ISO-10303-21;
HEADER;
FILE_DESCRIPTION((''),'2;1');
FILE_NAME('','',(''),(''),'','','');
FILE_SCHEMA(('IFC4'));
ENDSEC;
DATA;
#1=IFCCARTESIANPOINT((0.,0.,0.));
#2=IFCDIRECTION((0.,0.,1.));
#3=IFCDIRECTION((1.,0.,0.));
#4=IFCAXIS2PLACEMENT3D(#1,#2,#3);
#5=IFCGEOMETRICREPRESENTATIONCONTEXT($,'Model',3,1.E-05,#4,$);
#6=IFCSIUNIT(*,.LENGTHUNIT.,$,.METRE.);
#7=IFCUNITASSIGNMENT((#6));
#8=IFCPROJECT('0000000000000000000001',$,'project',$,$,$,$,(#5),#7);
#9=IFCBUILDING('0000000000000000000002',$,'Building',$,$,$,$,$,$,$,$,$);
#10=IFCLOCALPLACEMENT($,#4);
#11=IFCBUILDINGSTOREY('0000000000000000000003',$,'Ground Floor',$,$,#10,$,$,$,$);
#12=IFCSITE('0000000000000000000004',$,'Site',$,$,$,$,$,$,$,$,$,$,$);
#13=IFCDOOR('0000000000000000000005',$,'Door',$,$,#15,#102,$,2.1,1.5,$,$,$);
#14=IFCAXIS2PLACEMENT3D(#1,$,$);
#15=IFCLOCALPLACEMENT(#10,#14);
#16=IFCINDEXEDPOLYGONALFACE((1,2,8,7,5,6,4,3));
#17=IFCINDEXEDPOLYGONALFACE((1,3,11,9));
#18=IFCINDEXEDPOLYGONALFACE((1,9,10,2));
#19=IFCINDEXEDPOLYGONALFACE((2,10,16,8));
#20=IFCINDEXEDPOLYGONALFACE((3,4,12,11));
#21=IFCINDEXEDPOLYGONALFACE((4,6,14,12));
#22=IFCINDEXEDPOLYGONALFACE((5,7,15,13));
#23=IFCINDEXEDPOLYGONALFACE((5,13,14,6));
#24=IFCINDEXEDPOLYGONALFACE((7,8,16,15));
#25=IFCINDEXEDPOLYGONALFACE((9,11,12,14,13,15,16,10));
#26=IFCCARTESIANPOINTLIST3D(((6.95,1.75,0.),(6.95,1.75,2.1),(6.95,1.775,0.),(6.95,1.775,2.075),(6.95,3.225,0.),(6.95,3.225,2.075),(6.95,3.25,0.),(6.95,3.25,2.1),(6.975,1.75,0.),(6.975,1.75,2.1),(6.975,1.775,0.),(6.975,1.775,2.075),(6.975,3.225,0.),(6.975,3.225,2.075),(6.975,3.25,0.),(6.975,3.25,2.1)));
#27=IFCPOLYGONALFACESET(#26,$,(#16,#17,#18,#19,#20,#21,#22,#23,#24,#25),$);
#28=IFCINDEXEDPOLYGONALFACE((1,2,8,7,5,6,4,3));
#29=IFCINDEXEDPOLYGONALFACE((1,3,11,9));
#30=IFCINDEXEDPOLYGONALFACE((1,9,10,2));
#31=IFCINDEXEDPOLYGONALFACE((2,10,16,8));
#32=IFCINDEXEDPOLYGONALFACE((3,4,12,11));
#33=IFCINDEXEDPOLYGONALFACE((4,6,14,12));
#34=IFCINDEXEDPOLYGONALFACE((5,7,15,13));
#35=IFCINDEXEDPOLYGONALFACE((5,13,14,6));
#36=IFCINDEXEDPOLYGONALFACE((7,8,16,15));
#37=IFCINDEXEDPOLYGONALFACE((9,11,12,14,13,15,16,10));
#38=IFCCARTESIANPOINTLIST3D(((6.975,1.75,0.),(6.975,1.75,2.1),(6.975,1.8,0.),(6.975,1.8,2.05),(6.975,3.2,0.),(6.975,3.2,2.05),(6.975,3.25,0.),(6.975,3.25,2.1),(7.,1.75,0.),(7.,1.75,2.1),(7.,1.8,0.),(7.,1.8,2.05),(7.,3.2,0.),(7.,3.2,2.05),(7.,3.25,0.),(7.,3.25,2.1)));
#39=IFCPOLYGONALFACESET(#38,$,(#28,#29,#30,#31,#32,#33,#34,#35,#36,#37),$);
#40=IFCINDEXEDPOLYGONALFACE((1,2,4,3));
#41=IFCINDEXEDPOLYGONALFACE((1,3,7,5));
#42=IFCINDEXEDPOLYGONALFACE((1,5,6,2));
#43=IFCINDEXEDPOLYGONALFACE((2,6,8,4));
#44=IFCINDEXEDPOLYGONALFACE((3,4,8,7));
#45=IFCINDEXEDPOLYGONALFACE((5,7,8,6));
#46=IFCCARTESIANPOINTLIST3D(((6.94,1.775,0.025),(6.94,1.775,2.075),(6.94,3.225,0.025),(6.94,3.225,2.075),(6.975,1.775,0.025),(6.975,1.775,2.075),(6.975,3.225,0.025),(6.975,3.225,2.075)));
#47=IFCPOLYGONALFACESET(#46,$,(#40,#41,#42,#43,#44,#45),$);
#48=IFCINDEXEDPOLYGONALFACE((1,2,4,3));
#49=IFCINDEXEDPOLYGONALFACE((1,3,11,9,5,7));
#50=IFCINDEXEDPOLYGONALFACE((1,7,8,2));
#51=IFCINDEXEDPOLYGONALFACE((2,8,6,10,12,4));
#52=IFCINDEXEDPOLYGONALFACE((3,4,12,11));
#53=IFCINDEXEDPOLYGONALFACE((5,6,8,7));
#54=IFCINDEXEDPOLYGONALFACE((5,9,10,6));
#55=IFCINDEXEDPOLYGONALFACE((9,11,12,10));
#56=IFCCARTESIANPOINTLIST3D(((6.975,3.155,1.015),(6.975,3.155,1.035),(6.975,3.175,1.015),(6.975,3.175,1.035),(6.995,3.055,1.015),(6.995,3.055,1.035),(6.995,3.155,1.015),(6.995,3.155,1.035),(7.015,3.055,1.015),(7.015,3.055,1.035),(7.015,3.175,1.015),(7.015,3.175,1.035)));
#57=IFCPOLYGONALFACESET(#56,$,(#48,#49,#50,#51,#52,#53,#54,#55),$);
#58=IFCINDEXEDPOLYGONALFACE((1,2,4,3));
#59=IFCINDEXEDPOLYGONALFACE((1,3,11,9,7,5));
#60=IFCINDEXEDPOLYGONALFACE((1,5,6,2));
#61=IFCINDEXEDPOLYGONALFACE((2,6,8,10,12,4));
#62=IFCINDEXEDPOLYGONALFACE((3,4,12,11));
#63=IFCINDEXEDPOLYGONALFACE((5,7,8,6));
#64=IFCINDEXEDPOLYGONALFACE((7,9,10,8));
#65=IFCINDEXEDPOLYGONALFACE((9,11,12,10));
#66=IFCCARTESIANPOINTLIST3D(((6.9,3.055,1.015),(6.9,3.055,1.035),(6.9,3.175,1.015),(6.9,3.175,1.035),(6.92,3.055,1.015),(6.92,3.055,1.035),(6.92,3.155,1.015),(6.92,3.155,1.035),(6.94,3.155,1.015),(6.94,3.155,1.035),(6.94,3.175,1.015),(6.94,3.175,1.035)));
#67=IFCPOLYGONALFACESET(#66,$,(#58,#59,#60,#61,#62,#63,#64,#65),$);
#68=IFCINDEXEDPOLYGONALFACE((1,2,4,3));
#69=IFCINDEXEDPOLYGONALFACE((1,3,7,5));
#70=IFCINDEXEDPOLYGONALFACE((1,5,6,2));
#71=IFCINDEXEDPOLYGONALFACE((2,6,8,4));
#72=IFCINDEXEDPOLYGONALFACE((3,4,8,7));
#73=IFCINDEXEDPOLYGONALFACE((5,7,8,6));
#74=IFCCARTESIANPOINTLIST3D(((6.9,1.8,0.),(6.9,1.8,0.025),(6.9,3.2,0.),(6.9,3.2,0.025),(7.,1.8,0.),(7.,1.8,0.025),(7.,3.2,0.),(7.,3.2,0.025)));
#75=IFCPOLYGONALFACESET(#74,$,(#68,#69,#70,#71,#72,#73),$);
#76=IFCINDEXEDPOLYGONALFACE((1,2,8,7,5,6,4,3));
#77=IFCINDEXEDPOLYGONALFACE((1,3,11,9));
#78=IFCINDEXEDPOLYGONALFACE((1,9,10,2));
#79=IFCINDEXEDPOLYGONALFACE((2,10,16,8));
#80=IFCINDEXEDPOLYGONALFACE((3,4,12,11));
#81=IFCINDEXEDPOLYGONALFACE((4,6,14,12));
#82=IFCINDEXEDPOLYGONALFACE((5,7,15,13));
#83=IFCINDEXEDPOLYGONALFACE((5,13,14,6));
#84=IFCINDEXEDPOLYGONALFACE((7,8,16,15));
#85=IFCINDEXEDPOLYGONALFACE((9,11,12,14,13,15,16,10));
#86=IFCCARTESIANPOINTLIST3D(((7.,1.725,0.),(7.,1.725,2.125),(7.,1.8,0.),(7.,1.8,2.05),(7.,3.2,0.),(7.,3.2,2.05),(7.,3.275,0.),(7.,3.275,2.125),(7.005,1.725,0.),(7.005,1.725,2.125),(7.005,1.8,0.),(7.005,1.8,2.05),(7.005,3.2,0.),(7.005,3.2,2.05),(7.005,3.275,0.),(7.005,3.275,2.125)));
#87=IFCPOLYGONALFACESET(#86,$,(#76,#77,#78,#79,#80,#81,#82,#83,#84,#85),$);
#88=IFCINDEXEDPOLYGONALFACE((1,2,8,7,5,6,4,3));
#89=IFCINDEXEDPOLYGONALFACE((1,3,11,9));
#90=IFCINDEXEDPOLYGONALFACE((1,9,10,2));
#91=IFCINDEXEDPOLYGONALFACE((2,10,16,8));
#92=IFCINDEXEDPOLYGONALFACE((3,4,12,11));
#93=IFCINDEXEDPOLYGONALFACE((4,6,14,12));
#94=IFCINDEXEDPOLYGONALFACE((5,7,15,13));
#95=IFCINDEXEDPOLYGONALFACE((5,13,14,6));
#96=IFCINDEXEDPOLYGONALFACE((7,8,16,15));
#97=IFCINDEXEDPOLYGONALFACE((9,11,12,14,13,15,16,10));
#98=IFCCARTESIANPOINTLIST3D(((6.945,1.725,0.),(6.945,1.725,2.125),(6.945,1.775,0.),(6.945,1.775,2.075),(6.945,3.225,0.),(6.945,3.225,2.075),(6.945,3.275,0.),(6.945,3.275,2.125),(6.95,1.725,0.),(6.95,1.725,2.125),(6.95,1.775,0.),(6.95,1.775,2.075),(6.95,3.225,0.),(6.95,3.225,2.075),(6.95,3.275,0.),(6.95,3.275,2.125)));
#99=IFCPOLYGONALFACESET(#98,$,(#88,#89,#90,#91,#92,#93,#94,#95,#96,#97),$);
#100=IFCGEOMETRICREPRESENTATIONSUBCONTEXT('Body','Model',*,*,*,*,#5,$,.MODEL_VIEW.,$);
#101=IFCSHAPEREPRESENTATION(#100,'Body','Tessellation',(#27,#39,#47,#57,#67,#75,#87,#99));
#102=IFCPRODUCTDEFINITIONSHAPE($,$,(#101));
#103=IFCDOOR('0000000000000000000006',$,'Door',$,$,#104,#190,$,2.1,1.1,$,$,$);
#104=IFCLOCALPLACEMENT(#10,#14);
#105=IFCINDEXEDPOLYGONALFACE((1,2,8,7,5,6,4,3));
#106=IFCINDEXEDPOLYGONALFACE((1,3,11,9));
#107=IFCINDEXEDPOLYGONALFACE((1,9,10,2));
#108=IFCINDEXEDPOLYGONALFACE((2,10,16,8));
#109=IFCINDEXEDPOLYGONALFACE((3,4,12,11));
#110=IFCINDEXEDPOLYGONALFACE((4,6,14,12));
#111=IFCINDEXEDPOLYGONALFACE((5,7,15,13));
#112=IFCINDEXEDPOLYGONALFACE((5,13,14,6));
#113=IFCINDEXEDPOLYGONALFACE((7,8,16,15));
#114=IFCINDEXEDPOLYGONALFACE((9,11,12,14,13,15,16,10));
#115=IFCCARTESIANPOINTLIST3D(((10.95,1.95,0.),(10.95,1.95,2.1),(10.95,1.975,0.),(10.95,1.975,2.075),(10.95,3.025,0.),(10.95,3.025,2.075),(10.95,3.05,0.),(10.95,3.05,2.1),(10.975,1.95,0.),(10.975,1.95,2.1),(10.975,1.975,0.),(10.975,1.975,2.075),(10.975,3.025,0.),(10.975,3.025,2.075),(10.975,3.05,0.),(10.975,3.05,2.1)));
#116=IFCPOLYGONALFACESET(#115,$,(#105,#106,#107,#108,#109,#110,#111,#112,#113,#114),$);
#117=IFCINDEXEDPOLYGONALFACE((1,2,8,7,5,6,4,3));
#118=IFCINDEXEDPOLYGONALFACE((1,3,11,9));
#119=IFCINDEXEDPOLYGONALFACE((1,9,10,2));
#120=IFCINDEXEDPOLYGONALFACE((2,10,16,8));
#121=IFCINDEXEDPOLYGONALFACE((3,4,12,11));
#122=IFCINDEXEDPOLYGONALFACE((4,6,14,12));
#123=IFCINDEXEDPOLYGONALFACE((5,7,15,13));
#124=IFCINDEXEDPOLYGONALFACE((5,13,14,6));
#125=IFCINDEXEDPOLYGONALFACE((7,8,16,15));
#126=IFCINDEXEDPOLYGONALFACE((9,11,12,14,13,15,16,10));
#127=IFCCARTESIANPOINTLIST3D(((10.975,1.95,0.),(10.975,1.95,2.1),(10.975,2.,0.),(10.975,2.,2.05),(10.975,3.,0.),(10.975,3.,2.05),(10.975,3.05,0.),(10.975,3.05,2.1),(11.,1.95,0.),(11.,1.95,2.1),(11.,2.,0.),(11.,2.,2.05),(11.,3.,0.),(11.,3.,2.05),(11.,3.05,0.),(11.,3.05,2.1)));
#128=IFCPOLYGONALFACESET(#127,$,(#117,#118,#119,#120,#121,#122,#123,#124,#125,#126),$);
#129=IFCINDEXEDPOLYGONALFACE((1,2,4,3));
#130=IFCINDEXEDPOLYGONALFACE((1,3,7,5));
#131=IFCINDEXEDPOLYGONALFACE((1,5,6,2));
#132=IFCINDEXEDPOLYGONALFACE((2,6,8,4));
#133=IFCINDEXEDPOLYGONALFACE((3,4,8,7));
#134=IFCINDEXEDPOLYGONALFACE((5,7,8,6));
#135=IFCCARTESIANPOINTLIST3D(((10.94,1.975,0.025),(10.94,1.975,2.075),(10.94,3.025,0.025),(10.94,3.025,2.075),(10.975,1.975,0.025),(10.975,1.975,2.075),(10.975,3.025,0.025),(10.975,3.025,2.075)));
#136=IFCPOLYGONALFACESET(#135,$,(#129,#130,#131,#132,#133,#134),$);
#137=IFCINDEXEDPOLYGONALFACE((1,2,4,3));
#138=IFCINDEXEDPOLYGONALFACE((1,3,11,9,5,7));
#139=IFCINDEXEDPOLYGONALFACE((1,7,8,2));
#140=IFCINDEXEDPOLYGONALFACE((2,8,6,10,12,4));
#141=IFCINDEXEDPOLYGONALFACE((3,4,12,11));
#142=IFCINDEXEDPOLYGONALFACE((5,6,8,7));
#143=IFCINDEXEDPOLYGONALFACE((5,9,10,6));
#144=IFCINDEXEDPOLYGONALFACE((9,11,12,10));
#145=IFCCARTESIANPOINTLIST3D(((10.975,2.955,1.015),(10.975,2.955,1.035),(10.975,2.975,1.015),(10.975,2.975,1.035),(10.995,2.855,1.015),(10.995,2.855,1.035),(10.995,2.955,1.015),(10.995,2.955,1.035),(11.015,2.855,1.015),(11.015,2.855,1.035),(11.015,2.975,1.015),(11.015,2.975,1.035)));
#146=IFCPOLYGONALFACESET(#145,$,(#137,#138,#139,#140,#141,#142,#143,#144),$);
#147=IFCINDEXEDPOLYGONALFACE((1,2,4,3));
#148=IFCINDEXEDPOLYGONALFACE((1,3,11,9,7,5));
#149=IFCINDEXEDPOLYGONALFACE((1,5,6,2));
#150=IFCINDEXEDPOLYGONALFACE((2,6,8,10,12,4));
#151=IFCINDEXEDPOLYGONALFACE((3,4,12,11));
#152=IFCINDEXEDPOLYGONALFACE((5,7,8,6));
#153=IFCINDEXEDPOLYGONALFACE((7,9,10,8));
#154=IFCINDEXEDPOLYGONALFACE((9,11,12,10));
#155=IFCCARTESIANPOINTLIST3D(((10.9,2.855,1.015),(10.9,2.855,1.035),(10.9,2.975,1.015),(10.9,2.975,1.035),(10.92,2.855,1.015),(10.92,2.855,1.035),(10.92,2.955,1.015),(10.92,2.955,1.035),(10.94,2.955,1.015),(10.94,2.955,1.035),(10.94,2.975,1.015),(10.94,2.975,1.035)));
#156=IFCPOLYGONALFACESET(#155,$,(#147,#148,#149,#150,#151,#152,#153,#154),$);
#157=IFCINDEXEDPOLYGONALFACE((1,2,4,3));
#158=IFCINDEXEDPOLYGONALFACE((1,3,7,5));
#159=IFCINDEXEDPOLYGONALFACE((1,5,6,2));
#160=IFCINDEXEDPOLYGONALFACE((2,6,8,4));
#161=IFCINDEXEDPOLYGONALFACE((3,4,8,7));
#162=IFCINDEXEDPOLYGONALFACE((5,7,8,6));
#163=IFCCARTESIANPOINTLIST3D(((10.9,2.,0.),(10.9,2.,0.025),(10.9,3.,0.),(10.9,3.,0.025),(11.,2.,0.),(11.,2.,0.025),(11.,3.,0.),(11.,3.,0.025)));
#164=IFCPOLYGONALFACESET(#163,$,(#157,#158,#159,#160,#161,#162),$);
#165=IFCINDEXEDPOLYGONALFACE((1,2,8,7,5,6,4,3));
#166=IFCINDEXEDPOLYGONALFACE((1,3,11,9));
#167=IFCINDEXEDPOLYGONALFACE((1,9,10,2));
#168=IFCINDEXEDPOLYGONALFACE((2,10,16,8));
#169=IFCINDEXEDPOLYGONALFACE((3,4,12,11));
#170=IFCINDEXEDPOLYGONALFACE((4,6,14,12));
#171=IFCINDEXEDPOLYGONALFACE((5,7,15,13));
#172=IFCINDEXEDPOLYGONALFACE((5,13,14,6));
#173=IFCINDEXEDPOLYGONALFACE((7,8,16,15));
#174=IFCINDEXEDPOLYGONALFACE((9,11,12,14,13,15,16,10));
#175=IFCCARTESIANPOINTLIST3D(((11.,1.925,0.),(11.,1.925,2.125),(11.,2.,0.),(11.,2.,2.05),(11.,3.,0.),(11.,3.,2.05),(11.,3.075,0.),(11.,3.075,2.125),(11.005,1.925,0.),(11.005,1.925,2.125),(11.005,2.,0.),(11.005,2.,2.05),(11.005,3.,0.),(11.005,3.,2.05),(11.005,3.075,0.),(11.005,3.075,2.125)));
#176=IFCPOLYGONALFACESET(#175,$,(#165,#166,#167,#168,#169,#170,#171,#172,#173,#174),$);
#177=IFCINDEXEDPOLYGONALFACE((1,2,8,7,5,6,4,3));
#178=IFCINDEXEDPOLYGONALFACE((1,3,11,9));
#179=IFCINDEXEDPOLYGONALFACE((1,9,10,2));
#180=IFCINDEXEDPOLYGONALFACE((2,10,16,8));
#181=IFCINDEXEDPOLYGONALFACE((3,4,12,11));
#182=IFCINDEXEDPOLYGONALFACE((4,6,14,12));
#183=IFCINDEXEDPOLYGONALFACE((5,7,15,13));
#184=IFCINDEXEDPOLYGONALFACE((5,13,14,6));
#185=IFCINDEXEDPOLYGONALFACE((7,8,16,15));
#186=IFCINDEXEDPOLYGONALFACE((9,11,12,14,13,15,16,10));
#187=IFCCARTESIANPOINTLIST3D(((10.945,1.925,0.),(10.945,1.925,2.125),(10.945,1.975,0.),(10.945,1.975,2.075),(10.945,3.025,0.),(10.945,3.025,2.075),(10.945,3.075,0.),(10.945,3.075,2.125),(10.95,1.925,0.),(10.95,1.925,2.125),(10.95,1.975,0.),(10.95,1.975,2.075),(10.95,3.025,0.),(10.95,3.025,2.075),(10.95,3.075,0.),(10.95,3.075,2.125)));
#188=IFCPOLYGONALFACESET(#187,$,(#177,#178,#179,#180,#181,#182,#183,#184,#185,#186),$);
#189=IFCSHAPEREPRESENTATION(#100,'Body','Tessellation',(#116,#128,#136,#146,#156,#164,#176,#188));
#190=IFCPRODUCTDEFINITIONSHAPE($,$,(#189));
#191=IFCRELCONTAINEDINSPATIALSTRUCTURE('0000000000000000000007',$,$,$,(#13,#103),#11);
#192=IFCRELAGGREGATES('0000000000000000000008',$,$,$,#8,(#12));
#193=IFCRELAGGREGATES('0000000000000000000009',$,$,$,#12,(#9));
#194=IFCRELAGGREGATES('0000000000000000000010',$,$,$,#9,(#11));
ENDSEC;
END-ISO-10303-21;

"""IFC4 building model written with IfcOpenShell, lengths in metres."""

from ifc_helpers import new_model, si_unit, frame, origin_with_axes, place, context, subcontext, project, spatial, line, indexed_curve, outline, extrude, element, save


model = new_model("IFC4")

# Units and contexts
model_context = context("Model", 3, precision=1e-05, world=origin_with_axes())
body_context = subcontext(model_context, "Body", "Model", "MODEL_VIEW")
ifc_project = project(units=[si_unit("LENGTHUNIT", "METRE")], contexts=[model_context])

# Site, building, storey
site = spatial("IfcSite", under=ifc_project, Name="Site")
building = spatial("IfcBuilding", under=site, Name="Building")
storey_placement = place(None, origin_with_axes())
storey = spatial("IfcBuildingStorey", under=building, at=storey_placement, Name="Ground Floor")

# Doors
door_1_placement = place(storey_placement, frame((7.0, 1.75, 0.0), z_axis=(0.0, 0.0, 1.0), x_axis=(0.0, 1.0, 0.0)))
element("IfcDoor", 1, at=door_1_placement, inside=storey, Name="Door", OverallHeight=2.1, OverallWidth=1.5, context=body_context, shape_type="SweptSolid", body=[
    extrude(outline(indexed_curve([(0.0, 0.0), (0.0, 2.1), (1.5, 2.1), (1.5, 0.0), (1.475, 0.0), (1.475, 2.075), (0.025, 2.075), (0.025, 0.0)], segments=[line(1, 2, 3, 4, 5, 6, 7, 8, 1)])), frame((0.0, 0.025, 0.0), z_axis=(0.0, -1.0, 0.0), x_axis=(1.0, 0.0, 0.0)), (0.0, 0.0, -1.0), 0.025),
    extrude(outline(indexed_curve([(0.0, 0.0), (0.0, 2.1), (1.5, 2.1), (1.5, 0.0), (1.45, 0.0), (1.45, 2.05), (0.05, 2.05), (0.05, 0.0)], segments=[line(1, 2, 3, 4, 5, 6, 7, 8, 1)])), frame((0.0, 0.0, 0.0), z_axis=(0.0, -1.0, 0.0), x_axis=(1.0, 0.0, 0.0)), (0.0, 0.0, -1.0), 0.025),
    extrude(outline(indexed_curve([(0.0, 0.0), (1.45, 0.0), (1.45, 0.035), (0.0, 0.035)], segments=[line(1, 2, 3, 4, 1)])), frame((0.025, 0.025, 0.025), z_axis=(0.0, 0.0, 1.0), x_axis=(1.0, 0.0, 0.0)), (0.0, 0.0, 1.0), 2.05),
    extrude(outline(indexed_curve([(0.0, 0.0), (0.0, -0.04), (-0.12, -0.04), (-0.12, -0.02), (-0.02, -0.02), (-0.02, 0.0)], segments=[line(1, 2, 3, 4, 5, 6, 1)])), frame((1.425, 0.025, 1.015), z_axis=(0.0, 0.0, 1.0), x_axis=(1.0, 0.0, 0.0)), (0.0, 0.0, 1.0), 0.02),
    extrude(outline(indexed_curve([(0.0, 0.0), (0.0, 0.04), (-0.12, 0.04), (-0.12, 0.02), (-0.02, 0.02), (-0.02, 0.0)], segments=[line(1, 2, 3, 4, 5, 6, 1)])), frame((1.425, 0.06, 1.015), z_axis=(0.0, 0.0, 1.0), x_axis=(1.0, 0.0, 0.0)), (0.0, 0.0, 1.0), 0.02),
    extrude(outline(indexed_curve([(0.0, 0.0), (1.4, 0.0), (1.4, 0.1), (0.0, 0.1)], segments=[line(1, 2, 3, 4, 1)])), frame((0.05, 0.0, 0.0), z_axis=(0.0, 0.0, 1.0), x_axis=(1.0, 0.0, 0.0)), (0.0, 0.0, 1.0), 0.025),
    extrude(outline(indexed_curve([(0.0, 0.0), (0.0, 2.125), (1.55, 2.125), (1.55, 0.0), (1.475, 0.0), (1.475, 2.05), (0.075, 2.05), (0.075, 0.0)], segments=[line(1, 2, 3, 4, 5, 6, 7, 8, 1)])), frame((-0.025, -0.005, 0.0), z_axis=(0.0, -1.0, 0.0), x_axis=(1.0, 0.0, 0.0)), (0.0, 0.0, -1.0), 0.005),
    extrude(outline(indexed_curve([(0.0, 0.0), (0.0, 2.125), (1.55, 2.125), (1.55, 0.0), (1.5, 0.0), (1.5, 2.075), (0.05, 2.075), (0.05, 0.0)], segments=[line(1, 2, 3, 4, 5, 6, 7, 8, 1)])), frame((-0.025, 0.05, 0.0), z_axis=(0.0, -1.0, 0.0), x_axis=(1.0, 0.0, 0.0)), (0.0, 0.0, -1.0), 0.005),
])
door_2_placement = place(storey_placement, frame((11.0, 1.95, 0.0), z_axis=(0.0, 0.0, 1.0), x_axis=(0.0, 1.0, 0.0)))
element("IfcDoor", 2, at=door_2_placement, inside=storey, Name="Door", OverallHeight=2.1, OverallWidth=1.1, context=body_context, shape_type="SweptSolid", body=[
    extrude(outline(indexed_curve([(0.0, 0.0), (0.0, 2.1), (1.1, 2.1), (1.1, 0.0), (1.075, 0.0), (1.075, 2.075), (0.025, 2.075), (0.025, 0.0)], segments=[line(1, 2, 3, 4, 5, 6, 7, 8, 1)])), frame((0.0, 0.025, 0.0), z_axis=(0.0, -1.0, 0.0), x_axis=(1.0, 0.0, 0.0)), (0.0, 0.0, -1.0), 0.025),
    extrude(outline(indexed_curve([(0.0, 0.0), (0.0, 2.1), (1.1, 2.1), (1.1, 0.0), (1.05, 0.0), (1.05, 2.05), (0.05, 2.05), (0.05, 0.0)], segments=[line(1, 2, 3, 4, 5, 6, 7, 8, 1)])), frame((0.0, 0.0, 0.0), z_axis=(0.0, -1.0, 0.0), x_axis=(1.0, 0.0, 0.0)), (0.0, 0.0, -1.0), 0.025),
    extrude(outline(indexed_curve([(0.0, 0.0), (1.05, 0.0), (1.05, 0.035), (0.0, 0.035)], segments=[line(1, 2, 3, 4, 1)])), frame((0.025, 0.025, 0.025), z_axis=(0.0, 0.0, 1.0), x_axis=(1.0, 0.0, 0.0)), (0.0, 0.0, 1.0), 2.05),
    extrude(outline(indexed_curve([(0.0, 0.0), (0.0, -0.04), (-0.12, -0.04), (-0.12, -0.02), (-0.02, -0.02), (-0.02, 0.0)], segments=[line(1, 2, 3, 4, 5, 6, 1)])), frame((1.025, 0.025, 1.015), z_axis=(0.0, 0.0, 1.0), x_axis=(1.0, 0.0, 0.0)), (0.0, 0.0, 1.0), 0.02),
    extrude(outline(indexed_curve([(0.0, 0.0), (0.0, 0.04), (-0.12, 0.04), (-0.12, 0.02), (-0.02, 0.02), (-0.02, 0.0)], segments=[line(1, 2, 3, 4, 5, 6, 1)])), frame((1.025, 0.06, 1.015), z_axis=(0.0, 0.0, 1.0), x_axis=(1.0, 0.0, 0.0)), (0.0, 0.0, 1.0), 0.02),
    extrude(outline(indexed_curve([(0.0, 0.0), (1.0, 0.0), (1.0, 0.1), (0.0, 0.1)], segments=[line(1, 2, 3, 4, 1)])), frame((0.05, 0.0, 0.0), z_axis=(0.0, 0.0, 1.0), x_axis=(1.0, 0.0, 0.0)), (0.0, 0.0, 1.0), 0.025),
    extrude(outline(indexed_curve([(0.0, 0.0), (0.0, 2.125), (1.15, 2.125), (1.15, 0.0), (1.075, 0.0), (1.075, 2.05), (0.075, 2.05), (0.075, 0.0)], segments=[line(1, 2, 3, 4, 5, 6, 7, 8, 1)])), frame((-0.025, -0.005, 0.0), z_axis=(0.0, -1.0, 0.0), x_axis=(1.0, 0.0, 0.0)), (0.0, 0.0, -1.0), 0.005),
    extrude(outline(indexed_curve([(0.0, 0.0), (0.0, 2.125), (1.15, 2.125), (1.15, 0.0), (1.1, 0.0), (1.1, 2.075), (0.05, 2.075), (0.05, 0.0)], segments=[line(1, 2, 3, 4, 5, 6, 7, 8, 1)])), frame((-0.025, 0.05, 0.0), z_axis=(0.0, -1.0, 0.0), x_axis=(1.0, 0.0, 0.0)), (0.0, 0.0, -1.0), 0.005),
])

save(model, "model.ifc")
